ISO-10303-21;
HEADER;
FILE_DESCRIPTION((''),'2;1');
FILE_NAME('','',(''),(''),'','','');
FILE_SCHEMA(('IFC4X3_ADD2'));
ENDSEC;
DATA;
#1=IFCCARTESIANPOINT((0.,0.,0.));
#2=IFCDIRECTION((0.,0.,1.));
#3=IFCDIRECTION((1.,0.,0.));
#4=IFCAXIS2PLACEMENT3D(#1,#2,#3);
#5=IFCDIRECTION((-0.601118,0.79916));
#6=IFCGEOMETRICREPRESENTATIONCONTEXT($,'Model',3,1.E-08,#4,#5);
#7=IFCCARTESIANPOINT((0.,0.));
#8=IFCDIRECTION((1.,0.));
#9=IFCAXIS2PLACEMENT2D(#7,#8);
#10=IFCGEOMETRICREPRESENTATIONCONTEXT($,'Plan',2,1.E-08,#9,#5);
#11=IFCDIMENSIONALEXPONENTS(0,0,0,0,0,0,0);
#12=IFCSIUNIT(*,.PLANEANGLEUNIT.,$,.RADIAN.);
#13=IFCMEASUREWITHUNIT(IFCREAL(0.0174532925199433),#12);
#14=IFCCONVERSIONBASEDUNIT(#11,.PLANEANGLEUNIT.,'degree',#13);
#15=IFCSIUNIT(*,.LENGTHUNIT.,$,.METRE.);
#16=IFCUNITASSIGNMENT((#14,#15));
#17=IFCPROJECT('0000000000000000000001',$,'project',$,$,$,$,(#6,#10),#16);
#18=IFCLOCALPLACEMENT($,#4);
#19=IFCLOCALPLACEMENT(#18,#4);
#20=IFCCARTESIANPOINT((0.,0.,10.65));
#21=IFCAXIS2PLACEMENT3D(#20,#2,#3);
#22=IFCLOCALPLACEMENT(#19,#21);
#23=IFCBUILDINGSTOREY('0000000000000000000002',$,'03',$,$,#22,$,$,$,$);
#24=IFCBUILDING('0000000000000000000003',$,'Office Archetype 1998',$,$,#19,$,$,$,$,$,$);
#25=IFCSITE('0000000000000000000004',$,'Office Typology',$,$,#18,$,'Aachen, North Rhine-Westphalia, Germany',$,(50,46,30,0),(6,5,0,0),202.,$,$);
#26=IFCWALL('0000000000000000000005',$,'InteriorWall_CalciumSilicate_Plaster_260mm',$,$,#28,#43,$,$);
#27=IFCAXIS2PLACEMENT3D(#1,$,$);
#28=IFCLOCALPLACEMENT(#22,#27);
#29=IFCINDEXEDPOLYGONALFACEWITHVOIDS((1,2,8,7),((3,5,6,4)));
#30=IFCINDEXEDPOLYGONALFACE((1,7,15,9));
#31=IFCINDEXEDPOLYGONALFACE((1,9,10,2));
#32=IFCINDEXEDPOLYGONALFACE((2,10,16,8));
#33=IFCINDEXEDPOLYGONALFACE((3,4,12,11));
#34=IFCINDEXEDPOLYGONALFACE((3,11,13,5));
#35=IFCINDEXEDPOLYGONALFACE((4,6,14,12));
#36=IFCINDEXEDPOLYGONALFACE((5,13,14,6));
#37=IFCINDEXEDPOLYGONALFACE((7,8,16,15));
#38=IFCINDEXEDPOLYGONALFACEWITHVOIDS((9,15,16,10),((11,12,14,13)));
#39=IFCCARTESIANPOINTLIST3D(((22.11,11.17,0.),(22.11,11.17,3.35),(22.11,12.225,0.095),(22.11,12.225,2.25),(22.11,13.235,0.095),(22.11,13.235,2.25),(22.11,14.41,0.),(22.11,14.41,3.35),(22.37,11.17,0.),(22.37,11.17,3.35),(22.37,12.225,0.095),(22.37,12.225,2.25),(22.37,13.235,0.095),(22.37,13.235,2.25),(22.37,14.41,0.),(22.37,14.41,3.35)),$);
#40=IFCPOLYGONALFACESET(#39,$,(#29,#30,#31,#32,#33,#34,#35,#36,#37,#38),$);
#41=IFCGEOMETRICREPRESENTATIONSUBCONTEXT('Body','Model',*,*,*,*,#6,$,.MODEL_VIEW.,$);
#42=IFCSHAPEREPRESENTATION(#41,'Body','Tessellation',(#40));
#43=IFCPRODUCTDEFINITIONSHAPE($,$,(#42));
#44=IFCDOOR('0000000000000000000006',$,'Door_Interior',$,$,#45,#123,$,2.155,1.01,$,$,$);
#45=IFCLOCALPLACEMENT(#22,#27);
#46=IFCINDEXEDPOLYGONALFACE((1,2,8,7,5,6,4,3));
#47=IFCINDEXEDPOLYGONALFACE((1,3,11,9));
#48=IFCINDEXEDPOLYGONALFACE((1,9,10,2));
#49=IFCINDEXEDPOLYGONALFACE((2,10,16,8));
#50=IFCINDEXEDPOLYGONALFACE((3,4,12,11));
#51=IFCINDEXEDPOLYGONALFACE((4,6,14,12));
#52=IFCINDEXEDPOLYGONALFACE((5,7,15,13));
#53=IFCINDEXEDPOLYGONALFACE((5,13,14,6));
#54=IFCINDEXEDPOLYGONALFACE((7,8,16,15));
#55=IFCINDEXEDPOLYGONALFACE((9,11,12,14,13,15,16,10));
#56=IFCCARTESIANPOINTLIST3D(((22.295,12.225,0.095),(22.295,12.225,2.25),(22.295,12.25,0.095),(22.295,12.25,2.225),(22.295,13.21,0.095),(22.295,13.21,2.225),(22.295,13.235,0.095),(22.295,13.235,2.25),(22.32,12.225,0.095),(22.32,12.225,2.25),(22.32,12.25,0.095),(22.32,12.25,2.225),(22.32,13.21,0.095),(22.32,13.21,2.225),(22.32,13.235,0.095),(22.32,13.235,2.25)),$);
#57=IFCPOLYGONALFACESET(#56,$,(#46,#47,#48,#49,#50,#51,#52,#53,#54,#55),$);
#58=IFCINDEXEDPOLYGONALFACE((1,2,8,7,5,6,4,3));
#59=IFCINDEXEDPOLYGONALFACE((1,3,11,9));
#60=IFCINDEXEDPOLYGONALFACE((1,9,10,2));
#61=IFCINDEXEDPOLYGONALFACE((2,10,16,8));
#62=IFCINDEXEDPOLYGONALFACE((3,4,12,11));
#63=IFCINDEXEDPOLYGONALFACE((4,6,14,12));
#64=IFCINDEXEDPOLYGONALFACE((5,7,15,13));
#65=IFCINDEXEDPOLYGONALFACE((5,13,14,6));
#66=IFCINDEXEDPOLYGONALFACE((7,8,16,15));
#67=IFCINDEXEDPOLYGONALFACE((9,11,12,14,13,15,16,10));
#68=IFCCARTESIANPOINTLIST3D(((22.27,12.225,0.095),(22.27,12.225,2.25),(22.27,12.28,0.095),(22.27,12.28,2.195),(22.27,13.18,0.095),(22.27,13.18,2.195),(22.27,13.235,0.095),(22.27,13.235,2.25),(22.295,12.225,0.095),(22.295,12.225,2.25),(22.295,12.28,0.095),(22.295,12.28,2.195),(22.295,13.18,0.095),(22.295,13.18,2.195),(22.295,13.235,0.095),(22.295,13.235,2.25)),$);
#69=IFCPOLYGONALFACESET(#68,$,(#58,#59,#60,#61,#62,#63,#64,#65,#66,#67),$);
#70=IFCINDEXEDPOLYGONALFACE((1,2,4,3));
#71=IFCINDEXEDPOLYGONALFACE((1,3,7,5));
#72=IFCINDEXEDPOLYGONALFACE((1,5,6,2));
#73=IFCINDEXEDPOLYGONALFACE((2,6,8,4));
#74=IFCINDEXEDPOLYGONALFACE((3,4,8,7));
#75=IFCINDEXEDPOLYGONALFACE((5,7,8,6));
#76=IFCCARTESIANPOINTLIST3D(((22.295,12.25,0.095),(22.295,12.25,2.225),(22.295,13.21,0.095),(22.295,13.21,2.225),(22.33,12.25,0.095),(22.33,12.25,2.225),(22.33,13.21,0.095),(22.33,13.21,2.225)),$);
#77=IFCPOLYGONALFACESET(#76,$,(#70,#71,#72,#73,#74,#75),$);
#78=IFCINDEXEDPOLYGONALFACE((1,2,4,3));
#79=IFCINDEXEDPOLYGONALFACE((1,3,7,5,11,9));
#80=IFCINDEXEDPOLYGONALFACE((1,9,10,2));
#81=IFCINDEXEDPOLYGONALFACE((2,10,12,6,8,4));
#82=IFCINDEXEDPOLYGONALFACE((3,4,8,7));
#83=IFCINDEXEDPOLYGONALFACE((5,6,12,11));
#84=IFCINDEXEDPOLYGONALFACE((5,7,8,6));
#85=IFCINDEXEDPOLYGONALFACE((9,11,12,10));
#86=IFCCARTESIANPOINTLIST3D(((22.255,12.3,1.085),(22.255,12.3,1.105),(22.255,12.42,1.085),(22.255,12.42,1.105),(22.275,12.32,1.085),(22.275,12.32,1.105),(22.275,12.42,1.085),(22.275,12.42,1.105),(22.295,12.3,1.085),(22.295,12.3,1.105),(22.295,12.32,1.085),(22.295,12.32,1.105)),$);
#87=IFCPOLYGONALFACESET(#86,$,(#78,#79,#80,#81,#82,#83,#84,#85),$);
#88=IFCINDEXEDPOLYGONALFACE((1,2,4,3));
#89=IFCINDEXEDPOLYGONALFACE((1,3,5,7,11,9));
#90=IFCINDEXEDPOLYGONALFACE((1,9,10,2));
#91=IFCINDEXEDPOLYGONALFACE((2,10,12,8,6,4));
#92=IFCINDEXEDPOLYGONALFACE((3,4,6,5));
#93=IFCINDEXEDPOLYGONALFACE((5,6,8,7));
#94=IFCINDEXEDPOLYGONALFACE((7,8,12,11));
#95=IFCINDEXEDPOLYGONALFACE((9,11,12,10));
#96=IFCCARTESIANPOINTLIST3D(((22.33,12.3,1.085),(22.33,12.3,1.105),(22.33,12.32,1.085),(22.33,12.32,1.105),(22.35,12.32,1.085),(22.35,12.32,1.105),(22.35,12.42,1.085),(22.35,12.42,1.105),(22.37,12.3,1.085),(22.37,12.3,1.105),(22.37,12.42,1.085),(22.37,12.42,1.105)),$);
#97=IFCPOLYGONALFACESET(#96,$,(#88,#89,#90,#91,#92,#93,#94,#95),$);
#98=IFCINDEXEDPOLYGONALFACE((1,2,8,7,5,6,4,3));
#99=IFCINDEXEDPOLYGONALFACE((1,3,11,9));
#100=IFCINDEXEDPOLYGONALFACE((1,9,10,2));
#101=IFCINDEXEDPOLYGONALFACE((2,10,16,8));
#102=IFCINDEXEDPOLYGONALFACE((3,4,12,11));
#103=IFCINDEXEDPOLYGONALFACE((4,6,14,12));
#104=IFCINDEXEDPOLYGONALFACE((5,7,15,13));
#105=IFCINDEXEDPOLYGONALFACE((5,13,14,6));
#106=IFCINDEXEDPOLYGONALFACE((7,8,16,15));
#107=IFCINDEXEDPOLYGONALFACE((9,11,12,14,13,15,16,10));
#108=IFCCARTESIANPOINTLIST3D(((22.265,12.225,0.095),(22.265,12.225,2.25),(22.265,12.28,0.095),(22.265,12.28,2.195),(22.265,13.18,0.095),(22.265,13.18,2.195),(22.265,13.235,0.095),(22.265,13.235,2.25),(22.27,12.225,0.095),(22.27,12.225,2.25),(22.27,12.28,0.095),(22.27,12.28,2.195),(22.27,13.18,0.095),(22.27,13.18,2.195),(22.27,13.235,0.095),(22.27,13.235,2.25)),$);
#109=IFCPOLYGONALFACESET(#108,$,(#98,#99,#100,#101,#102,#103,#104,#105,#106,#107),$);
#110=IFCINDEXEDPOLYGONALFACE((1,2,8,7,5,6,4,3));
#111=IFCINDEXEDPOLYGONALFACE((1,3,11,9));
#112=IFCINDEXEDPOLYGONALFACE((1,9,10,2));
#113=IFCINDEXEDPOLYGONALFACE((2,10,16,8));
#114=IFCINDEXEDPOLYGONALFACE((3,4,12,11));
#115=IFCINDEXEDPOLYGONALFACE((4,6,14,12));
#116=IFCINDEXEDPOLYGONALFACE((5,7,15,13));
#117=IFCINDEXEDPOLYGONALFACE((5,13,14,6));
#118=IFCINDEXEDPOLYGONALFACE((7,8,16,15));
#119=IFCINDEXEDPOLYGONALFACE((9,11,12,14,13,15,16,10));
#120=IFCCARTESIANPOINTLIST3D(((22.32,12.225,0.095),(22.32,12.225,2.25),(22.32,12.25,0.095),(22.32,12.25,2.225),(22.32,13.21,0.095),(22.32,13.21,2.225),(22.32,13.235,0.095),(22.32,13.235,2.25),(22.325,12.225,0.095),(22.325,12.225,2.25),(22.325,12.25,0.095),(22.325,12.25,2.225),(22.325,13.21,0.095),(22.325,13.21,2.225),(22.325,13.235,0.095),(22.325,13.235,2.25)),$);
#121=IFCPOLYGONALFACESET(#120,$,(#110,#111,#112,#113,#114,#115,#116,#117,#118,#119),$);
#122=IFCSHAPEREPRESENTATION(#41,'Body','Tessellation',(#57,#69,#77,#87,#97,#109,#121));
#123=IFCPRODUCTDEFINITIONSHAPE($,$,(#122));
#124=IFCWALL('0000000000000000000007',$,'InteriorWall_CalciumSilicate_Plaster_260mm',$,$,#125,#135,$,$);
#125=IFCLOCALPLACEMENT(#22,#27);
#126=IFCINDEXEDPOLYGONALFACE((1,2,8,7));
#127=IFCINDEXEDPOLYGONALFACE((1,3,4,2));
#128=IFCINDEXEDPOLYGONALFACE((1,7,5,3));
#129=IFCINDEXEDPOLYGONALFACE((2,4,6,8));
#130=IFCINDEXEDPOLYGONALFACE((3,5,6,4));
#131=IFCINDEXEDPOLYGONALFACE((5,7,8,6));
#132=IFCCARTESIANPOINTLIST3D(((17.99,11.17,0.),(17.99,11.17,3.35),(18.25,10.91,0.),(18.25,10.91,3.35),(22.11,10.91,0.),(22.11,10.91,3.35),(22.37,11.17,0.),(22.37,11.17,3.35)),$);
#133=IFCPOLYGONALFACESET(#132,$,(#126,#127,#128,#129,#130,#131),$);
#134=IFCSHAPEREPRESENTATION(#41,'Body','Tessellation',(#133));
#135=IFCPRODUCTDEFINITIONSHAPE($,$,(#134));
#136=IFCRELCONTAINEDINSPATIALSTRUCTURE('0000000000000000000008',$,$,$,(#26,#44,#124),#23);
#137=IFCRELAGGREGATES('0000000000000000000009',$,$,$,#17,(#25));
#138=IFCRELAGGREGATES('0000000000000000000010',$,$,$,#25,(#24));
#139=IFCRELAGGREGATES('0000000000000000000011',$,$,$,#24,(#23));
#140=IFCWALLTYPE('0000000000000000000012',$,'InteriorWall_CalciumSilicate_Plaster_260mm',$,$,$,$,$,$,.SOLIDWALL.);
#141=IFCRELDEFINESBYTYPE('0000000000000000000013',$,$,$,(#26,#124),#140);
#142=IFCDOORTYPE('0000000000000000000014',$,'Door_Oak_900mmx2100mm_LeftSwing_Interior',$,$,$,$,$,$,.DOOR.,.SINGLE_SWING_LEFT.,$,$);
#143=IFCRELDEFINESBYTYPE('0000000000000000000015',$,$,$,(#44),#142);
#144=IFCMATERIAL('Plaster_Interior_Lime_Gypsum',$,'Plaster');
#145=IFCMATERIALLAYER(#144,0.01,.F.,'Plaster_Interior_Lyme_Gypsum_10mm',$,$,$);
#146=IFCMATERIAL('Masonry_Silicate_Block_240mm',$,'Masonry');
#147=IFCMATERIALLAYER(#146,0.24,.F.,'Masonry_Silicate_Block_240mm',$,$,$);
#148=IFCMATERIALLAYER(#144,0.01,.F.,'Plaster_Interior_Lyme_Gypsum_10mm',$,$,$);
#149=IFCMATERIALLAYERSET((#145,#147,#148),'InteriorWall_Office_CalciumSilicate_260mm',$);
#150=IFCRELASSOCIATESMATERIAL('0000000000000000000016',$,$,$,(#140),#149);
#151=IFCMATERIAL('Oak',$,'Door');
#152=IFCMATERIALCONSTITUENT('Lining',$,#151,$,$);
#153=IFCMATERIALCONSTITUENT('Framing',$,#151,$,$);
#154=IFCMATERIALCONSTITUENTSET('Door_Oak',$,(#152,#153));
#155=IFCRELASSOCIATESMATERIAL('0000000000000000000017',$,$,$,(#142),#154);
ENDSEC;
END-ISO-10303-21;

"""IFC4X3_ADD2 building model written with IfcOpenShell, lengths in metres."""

from ifc_helpers import new_model, entity, si_unit, converted_unit, direction, frame, origin_with_axes, origin_2d_with_axis, place, context, subcontext, project, spatial, line, indexed_curve, outline, extrude, source, transform, mapped, material, layer, layer_set, constituent, constituent_set, type_object, type_shapes, element, fill, save


model = new_model("IFC4X3_ADD2")

# Units and contexts
model_context = context("Model", 3, precision=1e-08, world=origin_with_axes(), true_north=direction((-0.601118, 0.79916)))
plan_context = context("Plan", 2, precision=1e-08, world=origin_2d_with_axis(), true_north=direction((-0.601118, 0.79916)))
body_context = subcontext(model_context, "Body", "Model", "MODEL_VIEW")
ifc_project = project(units=[converted_unit("PLANEANGLEUNIT", "degree", entity("IfcReal", 0.0174532925199433), si_unit("PLANEANGLEUNIT", "RADIAN"), dimensions=[0, 0, 0, 0, 0, 0, 0]), si_unit("LENGTHUNIT", "METRE")], contexts=[model_context, plan_context])

# Site, building, storey
site_placement = place(None, origin_with_axes())
site = spatial("IfcSite", under=ifc_project, at=site_placement, Name="Office Typology", LongName="Aachen, North Rhine-Westphalia, Germany", RefLatitude=(50, 46, 30, 0), RefLongitude=(6, 5, 0, 0), RefElevation=202.0)
building_placement = place(site_placement, origin_with_axes())
building = spatial("IfcBuilding", under=site, at=building_placement, Name="Office Archetype 1998")
storey_placement = place(building_placement, frame((0.0, 0.0, 10.65), z_axis=(0.0, 0.0, 1.0), x_axis=(1.0, 0.0, 0.0)))
storey = spatial("IfcBuildingStorey", under=building, at=storey_placement, Name="03")

# Wall, opening, door
ifc_material_1 = material(Name="Plaster_Interior_Lime_Gypsum", Category="Plaster")
ifc_layer_1 = layer(ifc_material_1, 0.01, ventilated=False, Name="Plaster_Interior_Lyme_Gypsum_10mm")
ifc_material_2 = material(Name="Masonry_Silicate_Block_240mm", Category="Masonry")
ifc_layer_2 = layer(ifc_material_2, 0.24, ventilated=False, Name="Masonry_Silicate_Block_240mm")
ifc_layer_3 = layer(ifc_material_1, 0.01, ventilated=False, Name="Plaster_Interior_Lyme_Gypsum_10mm")
ifc_layer_set_1 = layer_set([ifc_layer_1, ifc_layer_2, ifc_layer_3], Name="InteriorWall_Office_CalciumSilicate_260mm")
wall_type_1 = type_object("IfcWallType", Name="InteriorWall_CalciumSilicate_Plaster_260mm", PredefinedType="SOLIDWALL", material=ifc_layer_set_1)
wall_1_placement = place(storey_placement, frame((22.37, 11.17, 0.0), z_axis=(0.0, 0.0, 1.0), x_axis=(0.0, 1.0, 0.0)))
wall_1 = element("IfcWall", 1, at=wall_1_placement, inside=storey, type_object=wall_type_1, Name="InteriorWall_CalciumSilicate_Plaster_260mm", context=body_context, shape_type="SweptSolid", body=[
    extrude(outline(indexed_curve([(0.0, 0.0), (0.0, 0.26), (3.24, 0.26), (3.24, 0.0)], segments=[line(1, 2, 3, 4, 1)])), origin_with_axes(), (0.0, 0.0, 1.0), 3.35),
])
shared_shape_1 = source(origin_with_axes(), body_context, "Body", "SweptSolid", [
    extrude(outline(indexed_curve([(0.0, 2.155), (1.01, 2.155), (1.01, 0.0), (0.0, 0.0), (0.0, 2.155)])), frame((0.0, -0.015, 0.0), z_axis=(0.0, -1.0, 0.0), x_axis=(1.0, 0.0, 0.0)), (0.0, 0.0, -1.0), 0.26),
])
opening_1_placement = place(wall_1_placement, frame((2.065, 0.245, 0.095), z_axis=(0.0, 0.0, 1.0), x_axis=(-1.0, 0.0, 0.0)))
opening_1 = element("IfcOpeningElement", 2, at=opening_1_placement, cuts=wall_1, PredefinedType="OPENING", context=body_context, shape_type="MappedRepresentation", body=[
    mapped(shared_shape_1, transform((0.0, 0.0, 0.0), x_axis=(1.0, 0.0, 0.0), y_axis=(0.0, 1.0, 0.0), z_axis=(0.0, 0.0, 1.0), scale=1.0)),
])
ifc_material_3 = material(Name="Oak", Category="Door")
ifc_constituent_1 = constituent(ifc_material_3, Name="Lining")
ifc_constituent_2 = constituent(ifc_material_3, Name="Framing")
ifc_constituent_set_1 = constituent_set(constituents=[ifc_constituent_1, ifc_constituent_2], Name="Door_Oak")
door_type = type_object("IfcDoorType", Name="Door_Oak_900mmx2100mm_LeftSwing_Interior", OperationType="SINGLE_SWING_LEFT", PredefinedType="DOOR", material=ifc_constituent_set_1)
shared_shape_2 = source(origin_with_axes(), body_context, "Body", "SweptSolid", [
    extrude(outline(indexed_curve([(0.0, 0.0), (0.0, 2.155), (1.01, 2.155), (1.01, 0.0), (0.985, 0.0), (0.985, 2.13), (0.025, 2.13), (0.025, 0.0)], segments=[line(1, 2, 3, 4, 5, 6, 7, 8, 1)])), frame((0.0, 0.025, 0.0), z_axis=(0.0, -1.0, 0.0), x_axis=(1.0, 0.0, 0.0)), (0.0, 0.0, -1.0), 0.025),
    extrude(outline(indexed_curve([(0.0, 0.0), (0.0, 2.155), (1.01, 2.155), (1.01, 0.0), (0.955, 0.0), (0.955, 2.1), (0.055, 2.1), (0.055, 0.0)], segments=[line(1, 2, 3, 4, 5, 6, 7, 8, 1)])), frame((0.0, 0.0, 0.0), z_axis=(0.0, -1.0, 0.0), x_axis=(1.0, 0.0, 0.0)), (0.0, 0.0, -1.0), 0.025),
    extrude(outline(indexed_curve([(0.0, 0.0), (0.96, 0.0), (0.96, 0.035), (0.0, 0.035)], segments=[line(1, 2, 3, 4, 1)])), frame((0.025, 0.025, 0.0), z_axis=(0.0, 0.0, 1.0), x_axis=(1.0, 0.0, 0.0)), (0.0, 0.0, 1.0), 2.13),
    extrude(outline(indexed_curve([(0.0, 0.0), (0.0, -0.04), (-0.12, -0.04), (-0.12, -0.02), (-0.02, -0.02), (-0.02, 0.0)], segments=[line(1, 2, 3, 4, 5, 6, 1)])), frame((0.935, 0.025, 0.99), z_axis=(0.0, 0.0, 1.0), x_axis=(1.0, 0.0, 0.0)), (0.0, 0.0, 1.0), 0.02),
    extrude(outline(indexed_curve([(0.0, 0.0), (0.0, 0.04), (-0.12, 0.04), (-0.12, 0.02), (-0.02, 0.02), (-0.02, 0.0)], segments=[line(1, 2, 3, 4, 5, 6, 1)])), frame((0.935, 0.06, 0.99), z_axis=(0.0, 0.0, 1.0), x_axis=(1.0, 0.0, 0.0)), (0.0, 0.0, 1.0), 0.02),
    extrude(outline(indexed_curve([(0.0, 0.0), (0.0, 2.155), (1.01, 2.155), (1.01, 0.0), (0.955, 0.0), (0.955, 2.1), (0.055, 2.1), (0.055, 0.0)], segments=[line(1, 2, 3, 4, 5, 6, 7, 8, 1)])), frame((0.0, -0.005, 0.0), z_axis=(0.0, -1.0, 0.0), x_axis=(1.0, 0.0, 0.0)), (0.0, 0.0, -1.0), 0.005),
    extrude(outline(indexed_curve([(0.0, 0.0), (0.0, 2.155), (1.01, 2.155), (1.01, 0.0), (0.985, 0.0), (0.985, 2.13), (0.025, 2.13), (0.025, 0.0)], segments=[line(1, 2, 3, 4, 5, 6, 7, 8, 1)])), frame((0.0, 0.05, 0.0), z_axis=(0.0, -1.0, 0.0), x_axis=(1.0, 0.0, 0.0)), (0.0, 0.0, -1.0), 0.005),
])
type_shapes(door_type, [shared_shape_2])
door_placement = place(opening_1_placement, frame((0.0, 0.145, 0.0), z_axis=(0.0, 0.0, 1.0), x_axis=(1.0, 0.0, 0.0)))
door = element("IfcDoor", 3, at=door_placement, inside=storey, type_object=door_type, Name="Door_Interior", OverallHeight=2.155, OverallWidth=1.01, context=body_context, shape_type="MappedRepresentation", body=[
    mapped(shared_shape_2, transform((0.0, 0.0, 0.0), x_axis=(1.0, 0.0, 0.0), y_axis=(0.0, 1.0, 0.0), z_axis=(0.0, 0.0, 1.0), scale=1.0)),
])
fill(opening_1, door)

# Wall
wall_2_placement = place(storey_placement, frame((22.37, 11.17, 0.0), z_axis=(0.0, 0.0, 1.0), x_axis=(-1.0, 0.0, 0.0)))
element("IfcWall", 4, at=wall_2_placement, inside=storey, type_object=wall_type_1, Name="InteriorWall_CalciumSilicate_Plaster_260mm", context=body_context, shape_type="SweptSolid", body=[
    extrude(outline(indexed_curve([(0.0, 0.0), (0.26, 0.26), (4.12, 0.26), (4.38, 0.0)], segments=[line(1, 2, 3, 4, 1)])), origin_with_axes(), (0.0, 0.0, 1.0), 3.35),
])

save(model, "model.ifc")
